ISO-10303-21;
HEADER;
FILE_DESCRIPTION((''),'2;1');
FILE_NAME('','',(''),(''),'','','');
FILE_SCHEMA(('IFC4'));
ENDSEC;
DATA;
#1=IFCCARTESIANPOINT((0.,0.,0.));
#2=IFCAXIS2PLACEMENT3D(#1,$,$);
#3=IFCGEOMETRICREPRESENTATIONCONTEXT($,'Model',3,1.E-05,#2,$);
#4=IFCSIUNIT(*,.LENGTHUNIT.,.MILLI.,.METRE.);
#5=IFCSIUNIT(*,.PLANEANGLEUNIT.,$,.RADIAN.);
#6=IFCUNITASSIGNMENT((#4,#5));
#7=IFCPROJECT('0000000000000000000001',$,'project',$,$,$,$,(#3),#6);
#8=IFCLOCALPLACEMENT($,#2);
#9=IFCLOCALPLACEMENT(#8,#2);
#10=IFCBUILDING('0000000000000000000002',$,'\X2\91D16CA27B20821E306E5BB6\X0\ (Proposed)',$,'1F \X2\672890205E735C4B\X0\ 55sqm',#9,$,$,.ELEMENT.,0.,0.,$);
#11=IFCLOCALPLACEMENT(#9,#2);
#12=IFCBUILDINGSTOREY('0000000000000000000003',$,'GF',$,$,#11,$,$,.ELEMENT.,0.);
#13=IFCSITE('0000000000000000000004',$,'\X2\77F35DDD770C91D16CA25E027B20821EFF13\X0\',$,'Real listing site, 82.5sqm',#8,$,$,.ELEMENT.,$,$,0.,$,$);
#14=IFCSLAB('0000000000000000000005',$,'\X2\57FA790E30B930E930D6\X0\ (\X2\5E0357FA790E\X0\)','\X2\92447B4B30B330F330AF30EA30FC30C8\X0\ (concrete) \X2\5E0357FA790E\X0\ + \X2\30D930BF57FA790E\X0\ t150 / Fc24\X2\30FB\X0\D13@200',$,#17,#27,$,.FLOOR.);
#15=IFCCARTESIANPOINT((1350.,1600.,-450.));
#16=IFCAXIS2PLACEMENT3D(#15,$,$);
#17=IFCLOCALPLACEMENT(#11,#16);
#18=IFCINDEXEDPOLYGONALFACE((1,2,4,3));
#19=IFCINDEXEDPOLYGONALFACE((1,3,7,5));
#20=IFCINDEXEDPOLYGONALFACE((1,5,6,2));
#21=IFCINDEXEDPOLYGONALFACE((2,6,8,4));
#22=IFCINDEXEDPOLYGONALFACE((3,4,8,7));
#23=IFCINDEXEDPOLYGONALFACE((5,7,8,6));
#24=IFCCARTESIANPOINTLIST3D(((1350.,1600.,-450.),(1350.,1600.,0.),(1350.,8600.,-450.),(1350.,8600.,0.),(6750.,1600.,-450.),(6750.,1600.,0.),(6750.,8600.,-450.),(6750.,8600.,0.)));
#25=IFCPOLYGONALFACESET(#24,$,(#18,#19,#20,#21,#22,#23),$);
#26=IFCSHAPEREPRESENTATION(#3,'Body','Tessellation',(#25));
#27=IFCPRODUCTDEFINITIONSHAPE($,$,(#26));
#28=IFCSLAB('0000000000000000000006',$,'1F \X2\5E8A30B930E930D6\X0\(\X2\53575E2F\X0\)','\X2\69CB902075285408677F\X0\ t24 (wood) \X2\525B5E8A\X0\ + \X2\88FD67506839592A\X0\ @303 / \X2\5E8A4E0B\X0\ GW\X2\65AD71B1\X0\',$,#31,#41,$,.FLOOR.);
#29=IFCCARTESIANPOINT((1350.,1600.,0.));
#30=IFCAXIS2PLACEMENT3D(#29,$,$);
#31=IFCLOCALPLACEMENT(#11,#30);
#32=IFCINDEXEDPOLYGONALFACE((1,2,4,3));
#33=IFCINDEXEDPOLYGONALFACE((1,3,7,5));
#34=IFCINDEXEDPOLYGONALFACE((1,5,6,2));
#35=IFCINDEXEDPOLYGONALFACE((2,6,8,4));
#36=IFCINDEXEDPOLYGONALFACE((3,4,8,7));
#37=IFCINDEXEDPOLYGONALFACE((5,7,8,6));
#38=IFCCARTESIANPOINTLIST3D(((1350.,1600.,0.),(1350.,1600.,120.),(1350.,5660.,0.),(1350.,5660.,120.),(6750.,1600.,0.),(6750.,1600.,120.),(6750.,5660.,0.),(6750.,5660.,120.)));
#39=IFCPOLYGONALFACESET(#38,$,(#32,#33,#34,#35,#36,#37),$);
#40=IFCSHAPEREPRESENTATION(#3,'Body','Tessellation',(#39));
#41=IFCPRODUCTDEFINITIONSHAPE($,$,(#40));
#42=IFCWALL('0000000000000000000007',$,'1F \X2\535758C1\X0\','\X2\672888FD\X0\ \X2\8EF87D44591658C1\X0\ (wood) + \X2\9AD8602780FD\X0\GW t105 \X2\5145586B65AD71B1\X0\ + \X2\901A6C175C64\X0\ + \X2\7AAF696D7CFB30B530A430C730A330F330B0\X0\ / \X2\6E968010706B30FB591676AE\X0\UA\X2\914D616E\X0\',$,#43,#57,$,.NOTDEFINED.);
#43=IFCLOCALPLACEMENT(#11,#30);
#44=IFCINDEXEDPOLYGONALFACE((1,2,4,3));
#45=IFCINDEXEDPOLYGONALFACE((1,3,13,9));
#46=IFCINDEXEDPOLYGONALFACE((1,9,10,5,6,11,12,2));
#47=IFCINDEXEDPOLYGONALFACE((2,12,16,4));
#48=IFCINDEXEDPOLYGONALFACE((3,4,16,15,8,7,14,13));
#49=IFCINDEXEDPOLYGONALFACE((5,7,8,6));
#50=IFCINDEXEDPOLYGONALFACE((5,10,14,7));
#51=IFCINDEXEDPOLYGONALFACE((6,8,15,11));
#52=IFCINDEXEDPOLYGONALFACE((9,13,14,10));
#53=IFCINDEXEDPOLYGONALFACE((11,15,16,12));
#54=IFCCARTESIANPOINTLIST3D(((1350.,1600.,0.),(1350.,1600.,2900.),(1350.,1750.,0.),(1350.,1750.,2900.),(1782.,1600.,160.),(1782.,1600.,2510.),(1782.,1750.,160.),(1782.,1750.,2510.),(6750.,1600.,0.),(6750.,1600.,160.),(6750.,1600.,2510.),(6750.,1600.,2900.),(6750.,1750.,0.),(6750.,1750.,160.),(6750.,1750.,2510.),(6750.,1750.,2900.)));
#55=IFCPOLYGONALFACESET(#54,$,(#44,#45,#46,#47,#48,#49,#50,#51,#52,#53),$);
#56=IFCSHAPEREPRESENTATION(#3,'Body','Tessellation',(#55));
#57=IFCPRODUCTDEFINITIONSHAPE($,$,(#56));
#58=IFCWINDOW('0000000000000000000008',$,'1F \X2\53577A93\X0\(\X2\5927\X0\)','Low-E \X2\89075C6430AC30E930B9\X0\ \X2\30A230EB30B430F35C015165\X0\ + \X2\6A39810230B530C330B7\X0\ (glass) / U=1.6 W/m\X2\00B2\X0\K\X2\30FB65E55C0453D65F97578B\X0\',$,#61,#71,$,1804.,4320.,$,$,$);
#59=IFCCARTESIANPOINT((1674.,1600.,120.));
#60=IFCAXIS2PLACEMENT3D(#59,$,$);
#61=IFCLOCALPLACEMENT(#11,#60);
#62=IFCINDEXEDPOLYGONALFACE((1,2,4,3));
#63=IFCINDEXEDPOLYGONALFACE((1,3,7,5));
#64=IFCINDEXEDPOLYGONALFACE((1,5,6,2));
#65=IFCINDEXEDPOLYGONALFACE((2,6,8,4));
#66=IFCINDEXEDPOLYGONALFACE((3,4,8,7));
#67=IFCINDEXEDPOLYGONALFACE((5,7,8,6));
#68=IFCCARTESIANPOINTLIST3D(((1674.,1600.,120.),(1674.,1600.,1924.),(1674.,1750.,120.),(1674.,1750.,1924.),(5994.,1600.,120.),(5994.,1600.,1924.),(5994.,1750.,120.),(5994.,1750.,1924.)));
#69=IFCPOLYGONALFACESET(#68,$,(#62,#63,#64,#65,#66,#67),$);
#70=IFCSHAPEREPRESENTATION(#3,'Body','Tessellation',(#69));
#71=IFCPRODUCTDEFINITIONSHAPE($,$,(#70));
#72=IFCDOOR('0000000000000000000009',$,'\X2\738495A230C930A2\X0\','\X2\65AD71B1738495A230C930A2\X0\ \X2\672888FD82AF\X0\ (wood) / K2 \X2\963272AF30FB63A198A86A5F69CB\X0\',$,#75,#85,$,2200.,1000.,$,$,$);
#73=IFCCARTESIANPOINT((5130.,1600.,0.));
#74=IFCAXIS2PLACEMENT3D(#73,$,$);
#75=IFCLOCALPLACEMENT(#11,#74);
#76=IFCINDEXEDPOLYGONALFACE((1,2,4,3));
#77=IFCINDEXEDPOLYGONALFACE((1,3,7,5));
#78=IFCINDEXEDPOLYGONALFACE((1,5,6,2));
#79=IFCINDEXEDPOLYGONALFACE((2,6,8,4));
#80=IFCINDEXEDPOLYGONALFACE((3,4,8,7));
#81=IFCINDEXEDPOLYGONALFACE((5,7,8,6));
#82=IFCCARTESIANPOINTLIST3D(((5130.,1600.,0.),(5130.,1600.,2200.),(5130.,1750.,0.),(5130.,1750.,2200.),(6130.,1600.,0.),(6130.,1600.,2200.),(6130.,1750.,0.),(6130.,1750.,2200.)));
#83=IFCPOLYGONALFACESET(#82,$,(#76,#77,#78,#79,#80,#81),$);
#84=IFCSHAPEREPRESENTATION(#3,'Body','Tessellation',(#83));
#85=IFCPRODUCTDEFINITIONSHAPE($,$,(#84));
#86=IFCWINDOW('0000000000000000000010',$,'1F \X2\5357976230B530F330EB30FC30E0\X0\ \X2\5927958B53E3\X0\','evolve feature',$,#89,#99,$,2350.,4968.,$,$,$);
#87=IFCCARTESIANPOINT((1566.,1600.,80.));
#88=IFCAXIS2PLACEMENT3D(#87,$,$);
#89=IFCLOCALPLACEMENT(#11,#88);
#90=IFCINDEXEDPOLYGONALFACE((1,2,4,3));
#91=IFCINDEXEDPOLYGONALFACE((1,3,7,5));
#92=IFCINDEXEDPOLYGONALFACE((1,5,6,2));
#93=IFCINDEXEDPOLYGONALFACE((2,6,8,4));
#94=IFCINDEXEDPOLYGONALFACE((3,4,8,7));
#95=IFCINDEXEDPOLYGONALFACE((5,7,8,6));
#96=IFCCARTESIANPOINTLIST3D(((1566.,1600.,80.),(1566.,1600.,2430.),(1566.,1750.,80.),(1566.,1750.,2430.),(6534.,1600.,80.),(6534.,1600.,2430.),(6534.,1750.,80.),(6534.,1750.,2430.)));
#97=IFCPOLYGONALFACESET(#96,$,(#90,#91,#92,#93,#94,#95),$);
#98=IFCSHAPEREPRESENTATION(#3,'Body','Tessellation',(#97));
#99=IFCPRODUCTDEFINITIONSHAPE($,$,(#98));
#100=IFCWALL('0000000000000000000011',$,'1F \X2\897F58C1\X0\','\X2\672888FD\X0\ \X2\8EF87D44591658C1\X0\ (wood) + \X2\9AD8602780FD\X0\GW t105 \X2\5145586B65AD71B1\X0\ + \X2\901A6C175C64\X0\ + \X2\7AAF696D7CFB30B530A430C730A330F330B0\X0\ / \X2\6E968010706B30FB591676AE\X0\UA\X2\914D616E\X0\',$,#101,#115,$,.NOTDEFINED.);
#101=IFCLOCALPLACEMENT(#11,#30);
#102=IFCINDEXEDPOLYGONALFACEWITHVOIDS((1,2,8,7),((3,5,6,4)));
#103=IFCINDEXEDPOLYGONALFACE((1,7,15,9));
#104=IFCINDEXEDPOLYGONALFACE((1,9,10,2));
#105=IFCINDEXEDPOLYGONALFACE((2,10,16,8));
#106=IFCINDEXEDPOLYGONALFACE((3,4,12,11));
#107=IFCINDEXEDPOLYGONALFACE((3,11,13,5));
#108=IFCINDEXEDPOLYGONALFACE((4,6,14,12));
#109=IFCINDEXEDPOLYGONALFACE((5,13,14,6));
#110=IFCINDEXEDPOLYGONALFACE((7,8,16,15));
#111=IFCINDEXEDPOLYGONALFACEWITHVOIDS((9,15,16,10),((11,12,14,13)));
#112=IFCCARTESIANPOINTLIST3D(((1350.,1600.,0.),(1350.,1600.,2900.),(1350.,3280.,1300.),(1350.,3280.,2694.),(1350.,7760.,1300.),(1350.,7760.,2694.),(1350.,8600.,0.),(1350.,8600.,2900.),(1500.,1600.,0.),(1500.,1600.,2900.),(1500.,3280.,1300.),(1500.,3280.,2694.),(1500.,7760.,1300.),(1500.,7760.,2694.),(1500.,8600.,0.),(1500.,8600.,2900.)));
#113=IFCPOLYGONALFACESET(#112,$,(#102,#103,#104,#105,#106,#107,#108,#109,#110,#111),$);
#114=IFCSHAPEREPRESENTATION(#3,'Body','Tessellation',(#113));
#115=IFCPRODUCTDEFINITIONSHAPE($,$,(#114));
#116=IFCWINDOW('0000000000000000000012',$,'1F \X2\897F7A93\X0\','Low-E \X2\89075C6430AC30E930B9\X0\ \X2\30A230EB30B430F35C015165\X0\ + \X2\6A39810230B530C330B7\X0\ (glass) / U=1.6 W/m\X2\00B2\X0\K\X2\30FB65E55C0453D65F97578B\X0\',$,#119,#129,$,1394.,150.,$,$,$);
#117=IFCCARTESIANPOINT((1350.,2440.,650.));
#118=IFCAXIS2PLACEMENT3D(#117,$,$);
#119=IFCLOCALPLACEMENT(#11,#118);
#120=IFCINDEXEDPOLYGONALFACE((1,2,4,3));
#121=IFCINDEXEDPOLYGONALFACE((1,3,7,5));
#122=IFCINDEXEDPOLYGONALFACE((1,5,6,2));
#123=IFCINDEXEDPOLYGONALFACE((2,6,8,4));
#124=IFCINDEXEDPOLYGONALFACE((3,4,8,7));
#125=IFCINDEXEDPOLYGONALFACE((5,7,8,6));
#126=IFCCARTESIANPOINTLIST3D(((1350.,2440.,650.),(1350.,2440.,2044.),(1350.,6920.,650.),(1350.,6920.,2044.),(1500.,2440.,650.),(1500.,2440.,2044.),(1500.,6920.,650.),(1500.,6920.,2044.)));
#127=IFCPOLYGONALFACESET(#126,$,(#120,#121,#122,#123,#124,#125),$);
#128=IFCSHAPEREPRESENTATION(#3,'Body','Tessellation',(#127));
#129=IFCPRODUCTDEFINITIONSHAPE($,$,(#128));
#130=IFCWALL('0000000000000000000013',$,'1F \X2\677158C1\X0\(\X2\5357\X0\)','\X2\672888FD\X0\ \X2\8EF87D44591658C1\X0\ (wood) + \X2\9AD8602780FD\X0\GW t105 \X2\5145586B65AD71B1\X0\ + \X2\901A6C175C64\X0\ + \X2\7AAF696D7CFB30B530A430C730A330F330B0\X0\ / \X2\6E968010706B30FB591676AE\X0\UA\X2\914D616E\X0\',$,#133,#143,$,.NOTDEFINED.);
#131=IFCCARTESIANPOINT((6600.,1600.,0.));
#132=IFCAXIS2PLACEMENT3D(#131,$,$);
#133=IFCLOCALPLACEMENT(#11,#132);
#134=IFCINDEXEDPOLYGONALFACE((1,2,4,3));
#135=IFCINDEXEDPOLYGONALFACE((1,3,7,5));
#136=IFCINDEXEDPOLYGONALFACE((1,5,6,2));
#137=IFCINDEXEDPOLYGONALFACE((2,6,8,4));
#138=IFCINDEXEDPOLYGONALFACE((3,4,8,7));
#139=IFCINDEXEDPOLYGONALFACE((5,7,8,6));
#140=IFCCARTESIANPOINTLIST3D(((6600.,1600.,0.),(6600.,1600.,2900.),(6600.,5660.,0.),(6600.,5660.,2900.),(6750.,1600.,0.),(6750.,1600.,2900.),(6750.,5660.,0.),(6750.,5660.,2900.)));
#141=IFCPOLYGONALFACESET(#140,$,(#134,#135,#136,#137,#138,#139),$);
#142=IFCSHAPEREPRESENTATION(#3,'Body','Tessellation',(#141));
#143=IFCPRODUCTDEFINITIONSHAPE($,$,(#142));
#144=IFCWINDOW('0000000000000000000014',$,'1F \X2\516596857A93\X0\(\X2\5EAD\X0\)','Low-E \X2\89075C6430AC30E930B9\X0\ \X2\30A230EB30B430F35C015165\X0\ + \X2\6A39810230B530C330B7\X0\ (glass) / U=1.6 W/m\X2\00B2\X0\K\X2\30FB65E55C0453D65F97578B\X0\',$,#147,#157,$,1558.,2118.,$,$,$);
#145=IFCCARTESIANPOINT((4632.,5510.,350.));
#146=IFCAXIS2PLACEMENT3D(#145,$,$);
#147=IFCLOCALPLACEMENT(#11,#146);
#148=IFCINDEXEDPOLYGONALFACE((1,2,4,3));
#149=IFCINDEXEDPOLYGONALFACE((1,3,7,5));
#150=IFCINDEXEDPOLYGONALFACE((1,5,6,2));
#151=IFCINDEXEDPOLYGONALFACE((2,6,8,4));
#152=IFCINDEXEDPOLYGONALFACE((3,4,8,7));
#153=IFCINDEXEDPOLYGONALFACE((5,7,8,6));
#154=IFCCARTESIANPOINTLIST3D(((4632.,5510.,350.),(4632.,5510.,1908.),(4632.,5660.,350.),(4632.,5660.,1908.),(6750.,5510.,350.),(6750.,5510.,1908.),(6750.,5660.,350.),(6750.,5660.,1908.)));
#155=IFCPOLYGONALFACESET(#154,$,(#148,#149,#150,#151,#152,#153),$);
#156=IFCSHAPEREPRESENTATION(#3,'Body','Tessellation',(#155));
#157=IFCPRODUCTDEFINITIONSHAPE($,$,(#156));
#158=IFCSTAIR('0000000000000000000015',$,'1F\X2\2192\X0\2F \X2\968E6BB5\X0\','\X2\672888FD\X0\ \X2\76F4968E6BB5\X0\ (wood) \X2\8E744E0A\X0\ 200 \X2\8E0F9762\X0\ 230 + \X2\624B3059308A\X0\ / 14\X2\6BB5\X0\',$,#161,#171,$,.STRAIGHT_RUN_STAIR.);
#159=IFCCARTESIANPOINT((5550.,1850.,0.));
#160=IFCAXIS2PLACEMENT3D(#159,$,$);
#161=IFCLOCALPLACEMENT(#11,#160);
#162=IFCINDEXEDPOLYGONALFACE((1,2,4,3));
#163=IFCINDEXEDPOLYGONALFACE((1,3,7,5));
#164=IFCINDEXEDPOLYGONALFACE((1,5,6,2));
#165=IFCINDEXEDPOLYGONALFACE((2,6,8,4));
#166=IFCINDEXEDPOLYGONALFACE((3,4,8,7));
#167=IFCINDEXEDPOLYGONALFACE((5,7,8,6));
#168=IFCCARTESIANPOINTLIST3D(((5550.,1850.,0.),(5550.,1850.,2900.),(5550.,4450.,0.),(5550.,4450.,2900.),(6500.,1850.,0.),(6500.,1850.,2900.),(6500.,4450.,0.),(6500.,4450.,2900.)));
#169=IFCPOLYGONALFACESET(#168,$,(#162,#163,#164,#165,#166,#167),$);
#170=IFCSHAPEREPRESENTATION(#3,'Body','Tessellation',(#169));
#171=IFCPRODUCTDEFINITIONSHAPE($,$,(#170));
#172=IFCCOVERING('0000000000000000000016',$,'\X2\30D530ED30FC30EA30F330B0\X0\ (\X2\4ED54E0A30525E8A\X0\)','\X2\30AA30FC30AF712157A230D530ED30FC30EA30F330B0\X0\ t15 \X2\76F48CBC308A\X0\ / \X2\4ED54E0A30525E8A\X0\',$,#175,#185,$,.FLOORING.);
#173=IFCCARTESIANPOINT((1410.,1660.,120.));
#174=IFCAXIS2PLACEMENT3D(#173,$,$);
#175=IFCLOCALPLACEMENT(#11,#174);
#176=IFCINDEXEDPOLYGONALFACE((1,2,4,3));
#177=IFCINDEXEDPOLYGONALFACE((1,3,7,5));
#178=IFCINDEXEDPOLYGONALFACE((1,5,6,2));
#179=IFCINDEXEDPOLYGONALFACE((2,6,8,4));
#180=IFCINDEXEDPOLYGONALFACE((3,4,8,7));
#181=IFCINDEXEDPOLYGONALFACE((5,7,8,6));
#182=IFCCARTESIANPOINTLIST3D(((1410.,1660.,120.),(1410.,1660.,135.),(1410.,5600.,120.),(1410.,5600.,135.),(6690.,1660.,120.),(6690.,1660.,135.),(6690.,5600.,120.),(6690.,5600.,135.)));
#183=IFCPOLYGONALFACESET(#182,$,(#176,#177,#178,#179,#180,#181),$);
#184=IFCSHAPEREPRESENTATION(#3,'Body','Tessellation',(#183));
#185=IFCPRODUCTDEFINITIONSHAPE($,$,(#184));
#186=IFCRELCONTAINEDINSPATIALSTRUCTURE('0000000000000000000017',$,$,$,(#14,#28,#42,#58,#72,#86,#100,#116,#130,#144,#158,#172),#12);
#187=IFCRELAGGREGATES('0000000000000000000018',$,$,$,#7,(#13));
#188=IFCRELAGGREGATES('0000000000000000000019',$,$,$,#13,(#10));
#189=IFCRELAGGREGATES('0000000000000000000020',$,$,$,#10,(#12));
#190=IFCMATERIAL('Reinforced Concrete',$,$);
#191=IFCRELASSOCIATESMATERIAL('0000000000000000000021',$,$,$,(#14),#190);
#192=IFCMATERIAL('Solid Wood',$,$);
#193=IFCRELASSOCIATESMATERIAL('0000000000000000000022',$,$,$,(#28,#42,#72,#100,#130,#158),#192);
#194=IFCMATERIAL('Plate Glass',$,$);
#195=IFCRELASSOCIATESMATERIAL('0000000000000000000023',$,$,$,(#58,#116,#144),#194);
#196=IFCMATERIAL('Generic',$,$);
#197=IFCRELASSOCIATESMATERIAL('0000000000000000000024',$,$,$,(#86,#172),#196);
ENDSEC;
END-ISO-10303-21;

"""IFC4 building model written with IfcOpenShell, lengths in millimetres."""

from ifc_helpers import new_model, si_unit, frame, frame_2d, origin, place, context, project, spatial, rectangle, extrude, material, element, fill, save


model = new_model("IFC4")

# Units and contexts
model_context = context("Model", 3, precision=1e-05, world=origin())
ifc_project = project(units=[si_unit("LENGTHUNIT", "METRE", prefix="MILLI"), si_unit("PLANEANGLEUNIT", "RADIAN")], contexts=[model_context])

# Site, building, storey
site_placement = place(None, origin())
site = spatial("IfcSite", under=ifc_project, at=site_placement, Name="石川県金沢市笠舞３", ObjectType="Real listing site, 82.5sqm", CompositionType="ELEMENT", RefElevation=0.0)
building_placement = place(site_placement, origin())
building = spatial("IfcBuilding", under=site, at=building_placement, Name="金沢笠舞の家 (Proposed)", ObjectType="1F 木造平屋 55sqm", CompositionType="ELEMENT", ElevationOfRefHeight=0.0, ElevationOfTerrain=0.0)
storey_placement = place(building_placement, origin())
storey = spatial("IfcBuildingStorey", under=building, at=storey_placement, Name="GF", CompositionType="ELEMENT", Elevation=0.0)

# Slabs
ifc_material_1 = material(Name="Reinforced Concrete")
slab_1_placement = place(storey_placement, frame((1350.0, 1600.0, -450.0)))
element("IfcSlab", 1, at=slab_1_placement, inside=storey, material=ifc_material_1, Name="基礎スラブ (布基礎)", Description="鉄筋コンクリート (concrete) 布基礎 + ベタ基礎 t150 / Fc24・D13@200", PredefinedType="FLOOR", context=model_context, shape_type="SweptSolid", body=[
    extrude(rectangle(XDim=5400.0, YDim=7000.0, at=frame_2d((2700.0, 3500.0))), frame((1350.0, 1600.0, -450.0)), (0.0, 0.0, 1.0), 450.0),
])
ifc_material_2 = material(Name="Solid Wood")
slab_2_placement = place(storey_placement, frame((1350.0, 1600.0, 0.0)))
element("IfcSlab", 2, at=slab_2_placement, inside=storey, material=ifc_material_2, Name="1F 床スラブ(南帯)", Description="構造用合板 t24 (wood) 剛床 + 製材根太 @303 / 床下 GW断熱", PredefinedType="FLOOR", context=model_context, shape_type="SweptSolid", body=[
    extrude(rectangle(XDim=5400.0, YDim=4060.0, at=frame_2d((2700.0, 2030.0))), frame((1350.0, 1600.0, 0.0)), (0.0, 0.0, 1.0), 120.0),
])

# Wall, openings, windows, door
wall_1_placement = place(storey_placement, frame((1350.0, 1600.0, 0.0)))
wall_1 = element("IfcWall", 3, at=wall_1_placement, inside=storey, material=ifc_material_2, Name="1F 南壁", Description="木製 軸組外壁 (wood) + 高性能GW t105 充填断熱 + 通気層 + 窯業系サイディング / 準耐火・外皮UA配慮", PredefinedType="NOTDEFINED", context=model_context, shape_type="SweptSolid", body=[
    extrude(rectangle(XDim=5400.0, YDim=150.0, at=frame_2d((2700.0, 75.0))), frame((1350.0, 1600.0, 0.0)), (0.0, 0.0, 1.0), 2900.0),
])
opening_1_placement = place(storey_placement, frame((1674.0, 1600.0, 120.0)))
opening_1 = element("IfcOpeningElement", 4, at=opening_1_placement, cuts=wall_1, PredefinedType="NOTDEFINED", context=model_context, shape_type="SweptSolid", body=[
    extrude(rectangle(XDim=4320.0, YDim=150.0, at=frame_2d((2160.0, 75.0))), frame((1674.0, 1600.0, 120.0)), (0.0, 0.0, 1.0), 1804.0),
])
opening_2_placement = place(storey_placement, frame((5130.0, 1600.0, 0.0)))
opening_2 = element("IfcOpeningElement", 5, at=opening_2_placement, cuts=wall_1, PredefinedType="NOTDEFINED", context=model_context, shape_type="SweptSolid", body=[
    extrude(rectangle(XDim=1000.0, YDim=150.0, at=frame_2d((500.0, 75.0))), frame((5130.0, 1600.0, 0.0)), (0.0, 0.0, 1.0), 2200.0),
])
opening_3_placement = place(storey_placement, frame((1566.0, 1600.0, 80.0)))
opening_3 = element("IfcOpeningElement", 6, at=opening_3_placement, cuts=wall_1, PredefinedType="NOTDEFINED", context=model_context, shape_type="SweptSolid", body=[
    extrude(rectangle(XDim=4968.0, YDim=150.0, at=frame_2d((2484.0, 75.0))), frame((1566.0, 1600.0, 80.0)), (0.0, 0.0, 1.0), 2350.0),
])
ifc_material_3 = material(Name="Plate Glass")
window_1_placement = place(storey_placement, frame((1674.0, 1600.0, 120.0)))
window_1 = element("IfcWindow", 7, at=window_1_placement, inside=storey, material=ifc_material_3, Name="1F 南窓(大)", Description="Low-E 複層ガラス アルゴン封入 + 樹脂サッシ (glass) / U=1.6 W/m²K・日射取得型", OverallHeight=1804.0, OverallWidth=4320.0, context=model_context, shape_type="SweptSolid", body=[
    extrude(rectangle(XDim=4320.0, YDim=150.0, at=frame_2d((2160.0, 75.0))), frame((1674.0, 1600.0, 120.0)), (0.0, 0.0, 1.0), 1804.0),
])
fill(opening_1, window_1)
door_1_placement = place(storey_placement, frame((5130.0, 1600.0, 0.0)))
door_1 = element("IfcDoor", 8, at=door_1_placement, inside=storey, material=ifc_material_2, Name="玄関ドア", Description="断熱玄関ドア 木製芯 (wood) / K2 防犯・採風機構", OverallHeight=2200.0, OverallWidth=1000.0, context=model_context, shape_type="SweptSolid", body=[
    extrude(rectangle(XDim=1000.0, YDim=150.0, at=frame_2d((500.0, 75.0))), frame((5130.0, 1600.0, 0.0)), (0.0, 0.0, 1.0), 2200.0),
])
fill(opening_2, door_1)
ifc_material_4 = material(Name="Generic")
window_2_placement = place(storey_placement, frame((1566.0, 1600.0, 80.0)))
window_2 = element("IfcWindow", 9, at=window_2_placement, inside=storey, material=ifc_material_4, Name="1F 南面サンルーム 大開口", Description="evolve feature", OverallHeight=2350.0, OverallWidth=4968.0, context=model_context, shape_type="SweptSolid", body=[
    extrude(rectangle(XDim=4968.0, YDim=150.0, at=frame_2d((2484.0, 75.0))), frame((1566.0, 1600.0, 80.0)), (0.0, 0.0, 1.0), 2350.0),
])
fill(opening_3, window_2)

# Walls, openings, windows
wall_2_placement = place(storey_placement, frame((1350.0, 1600.0, 0.0)))
wall_2 = element("IfcWall", 10, at=wall_2_placement, inside=storey, material=ifc_material_2, Name="1F 西壁", Description="木製 軸組外壁 (wood) + 高性能GW t105 充填断熱 + 通気層 + 窯業系サイディング / 準耐火・外皮UA配慮", PredefinedType="NOTDEFINED", context=model_context, shape_type="SweptSolid", body=[
    extrude(rectangle(XDim=150.0, YDim=7000.0, at=frame_2d((75.0, 3500.0))), frame((1350.0, 1600.0, 0.0)), (0.0, 0.0, 1.0), 2900.0),
])
opening_4_placement = place(storey_placement, frame((1350.0, 2440.0, 650.0)))
opening_4 = element("IfcOpeningElement", 11, at=opening_4_placement, cuts=wall_2, PredefinedType="NOTDEFINED", context=model_context, shape_type="SweptSolid", body=[
    extrude(rectangle(XDim=150.0, YDim=4480.0, at=frame_2d((75.0, 2240.0))), frame((1350.0, 2440.0, 650.0)), (0.0, 0.0, 1.0), 1394.0),
])
window_3_placement = place(storey_placement, frame((1350.0, 2440.0, 650.0)))
window_3 = element("IfcWindow", 12, at=window_3_placement, inside=storey, material=ifc_material_3, Name="1F 西窓", Description="Low-E 複層ガラス アルゴン封入 + 樹脂サッシ (glass) / U=1.6 W/m²K・日射取得型", OverallHeight=1394.0, OverallWidth=150.0, context=model_context, shape_type="SweptSolid", body=[
    extrude(rectangle(XDim=150.0, YDim=4480.0, at=frame_2d((75.0, 2240.0))), frame((1350.0, 2440.0, 650.0)), (0.0, 0.0, 1.0), 1394.0),
])
fill(opening_4, window_3)
wall_3_placement = place(storey_placement, frame((6600.0, 1600.0, 0.0)))
wall_3 = element("IfcWall", 13, at=wall_3_placement, inside=storey, material=ifc_material_2, Name="1F 東壁(南)", Description="木製 軸組外壁 (wood) + 高性能GW t105 充填断熱 + 通気層 + 窯業系サイディング / 準耐火・外皮UA配慮", PredefinedType="NOTDEFINED", context=model_context, shape_type="SweptSolid", body=[
    extrude(rectangle(XDim=150.0, YDim=4060.0, at=frame_2d((75.0, 2030.0))), frame((6600.0, 1600.0, 0.0)), (0.0, 0.0, 1.0), 2900.0),
])
opening_5_placement = place(storey_placement, frame((4632.0, 5510.0, 350.0)))
opening_5 = element("IfcOpeningElement", 14, at=opening_5_placement, cuts=wall_3, PredefinedType="NOTDEFINED", context=model_context, shape_type="SweptSolid", body=[
    extrude(rectangle(XDim=2118.0, YDim=150.0, at=frame_2d((1059.0, 75.0))), frame((4632.0, 5510.0, 350.0)), (0.0, 0.0, 1.0), 1558.0),
])
window_4_placement = place(storey_placement, frame((4632.0, 5510.0, 350.0)))
window_4 = element("IfcWindow", 15, at=window_4_placement, inside=storey, material=ifc_material_3, Name="1F 入隅窓(庭)", Description="Low-E 複層ガラス アルゴン封入 + 樹脂サッシ (glass) / U=1.6 W/m²K・日射取得型", OverallHeight=1558.0, OverallWidth=2118.0, context=model_context, shape_type="SweptSolid", body=[
    extrude(rectangle(XDim=2118.0, YDim=150.0, at=frame_2d((1059.0, 75.0))), frame((4632.0, 5510.0, 350.0)), (0.0, 0.0, 1.0), 1558.0),
])
fill(opening_5, window_4)

# Stair
stair_placement = place(storey_placement, frame((5550.0, 1850.0, 0.0)))
element("IfcStair", 16, at=stair_placement, inside=storey, material=ifc_material_2, Name="1F→2F 階段", Description="木製 直階段 (wood) 蹴上 200 踏面 230 + 手すり / 14段", PredefinedType="STRAIGHT_RUN_STAIR", context=model_context, shape_type="SweptSolid", body=[
    extrude(rectangle(XDim=950.0, YDim=2600.0, at=frame_2d((475.0, 1300.0))), frame((5550.0, 1850.0, 0.0)), (0.0, 0.0, 1.0), 2900.0),
])

# Covering
covering_placement = place(storey_placement, frame((1410.0, 1660.0, 120.0)))
element("IfcCovering", 17, at=covering_placement, inside=storey, material=ifc_material_4, Name="フローリング (仕上げ床)", Description="オーク無垢フローリング t15 直貼り / 仕上げ床", PredefinedType="FLOORING", context=model_context, shape_type="SweptSolid", body=[
    extrude(rectangle(XDim=5280.0, YDim=3940.0, at=frame_2d((2640.0, 1970.0))), frame((1410.0, 1660.0, 120.0)), (0.0, 0.0, 1.0), 15.0),
])

save(model, "model.ifc")
